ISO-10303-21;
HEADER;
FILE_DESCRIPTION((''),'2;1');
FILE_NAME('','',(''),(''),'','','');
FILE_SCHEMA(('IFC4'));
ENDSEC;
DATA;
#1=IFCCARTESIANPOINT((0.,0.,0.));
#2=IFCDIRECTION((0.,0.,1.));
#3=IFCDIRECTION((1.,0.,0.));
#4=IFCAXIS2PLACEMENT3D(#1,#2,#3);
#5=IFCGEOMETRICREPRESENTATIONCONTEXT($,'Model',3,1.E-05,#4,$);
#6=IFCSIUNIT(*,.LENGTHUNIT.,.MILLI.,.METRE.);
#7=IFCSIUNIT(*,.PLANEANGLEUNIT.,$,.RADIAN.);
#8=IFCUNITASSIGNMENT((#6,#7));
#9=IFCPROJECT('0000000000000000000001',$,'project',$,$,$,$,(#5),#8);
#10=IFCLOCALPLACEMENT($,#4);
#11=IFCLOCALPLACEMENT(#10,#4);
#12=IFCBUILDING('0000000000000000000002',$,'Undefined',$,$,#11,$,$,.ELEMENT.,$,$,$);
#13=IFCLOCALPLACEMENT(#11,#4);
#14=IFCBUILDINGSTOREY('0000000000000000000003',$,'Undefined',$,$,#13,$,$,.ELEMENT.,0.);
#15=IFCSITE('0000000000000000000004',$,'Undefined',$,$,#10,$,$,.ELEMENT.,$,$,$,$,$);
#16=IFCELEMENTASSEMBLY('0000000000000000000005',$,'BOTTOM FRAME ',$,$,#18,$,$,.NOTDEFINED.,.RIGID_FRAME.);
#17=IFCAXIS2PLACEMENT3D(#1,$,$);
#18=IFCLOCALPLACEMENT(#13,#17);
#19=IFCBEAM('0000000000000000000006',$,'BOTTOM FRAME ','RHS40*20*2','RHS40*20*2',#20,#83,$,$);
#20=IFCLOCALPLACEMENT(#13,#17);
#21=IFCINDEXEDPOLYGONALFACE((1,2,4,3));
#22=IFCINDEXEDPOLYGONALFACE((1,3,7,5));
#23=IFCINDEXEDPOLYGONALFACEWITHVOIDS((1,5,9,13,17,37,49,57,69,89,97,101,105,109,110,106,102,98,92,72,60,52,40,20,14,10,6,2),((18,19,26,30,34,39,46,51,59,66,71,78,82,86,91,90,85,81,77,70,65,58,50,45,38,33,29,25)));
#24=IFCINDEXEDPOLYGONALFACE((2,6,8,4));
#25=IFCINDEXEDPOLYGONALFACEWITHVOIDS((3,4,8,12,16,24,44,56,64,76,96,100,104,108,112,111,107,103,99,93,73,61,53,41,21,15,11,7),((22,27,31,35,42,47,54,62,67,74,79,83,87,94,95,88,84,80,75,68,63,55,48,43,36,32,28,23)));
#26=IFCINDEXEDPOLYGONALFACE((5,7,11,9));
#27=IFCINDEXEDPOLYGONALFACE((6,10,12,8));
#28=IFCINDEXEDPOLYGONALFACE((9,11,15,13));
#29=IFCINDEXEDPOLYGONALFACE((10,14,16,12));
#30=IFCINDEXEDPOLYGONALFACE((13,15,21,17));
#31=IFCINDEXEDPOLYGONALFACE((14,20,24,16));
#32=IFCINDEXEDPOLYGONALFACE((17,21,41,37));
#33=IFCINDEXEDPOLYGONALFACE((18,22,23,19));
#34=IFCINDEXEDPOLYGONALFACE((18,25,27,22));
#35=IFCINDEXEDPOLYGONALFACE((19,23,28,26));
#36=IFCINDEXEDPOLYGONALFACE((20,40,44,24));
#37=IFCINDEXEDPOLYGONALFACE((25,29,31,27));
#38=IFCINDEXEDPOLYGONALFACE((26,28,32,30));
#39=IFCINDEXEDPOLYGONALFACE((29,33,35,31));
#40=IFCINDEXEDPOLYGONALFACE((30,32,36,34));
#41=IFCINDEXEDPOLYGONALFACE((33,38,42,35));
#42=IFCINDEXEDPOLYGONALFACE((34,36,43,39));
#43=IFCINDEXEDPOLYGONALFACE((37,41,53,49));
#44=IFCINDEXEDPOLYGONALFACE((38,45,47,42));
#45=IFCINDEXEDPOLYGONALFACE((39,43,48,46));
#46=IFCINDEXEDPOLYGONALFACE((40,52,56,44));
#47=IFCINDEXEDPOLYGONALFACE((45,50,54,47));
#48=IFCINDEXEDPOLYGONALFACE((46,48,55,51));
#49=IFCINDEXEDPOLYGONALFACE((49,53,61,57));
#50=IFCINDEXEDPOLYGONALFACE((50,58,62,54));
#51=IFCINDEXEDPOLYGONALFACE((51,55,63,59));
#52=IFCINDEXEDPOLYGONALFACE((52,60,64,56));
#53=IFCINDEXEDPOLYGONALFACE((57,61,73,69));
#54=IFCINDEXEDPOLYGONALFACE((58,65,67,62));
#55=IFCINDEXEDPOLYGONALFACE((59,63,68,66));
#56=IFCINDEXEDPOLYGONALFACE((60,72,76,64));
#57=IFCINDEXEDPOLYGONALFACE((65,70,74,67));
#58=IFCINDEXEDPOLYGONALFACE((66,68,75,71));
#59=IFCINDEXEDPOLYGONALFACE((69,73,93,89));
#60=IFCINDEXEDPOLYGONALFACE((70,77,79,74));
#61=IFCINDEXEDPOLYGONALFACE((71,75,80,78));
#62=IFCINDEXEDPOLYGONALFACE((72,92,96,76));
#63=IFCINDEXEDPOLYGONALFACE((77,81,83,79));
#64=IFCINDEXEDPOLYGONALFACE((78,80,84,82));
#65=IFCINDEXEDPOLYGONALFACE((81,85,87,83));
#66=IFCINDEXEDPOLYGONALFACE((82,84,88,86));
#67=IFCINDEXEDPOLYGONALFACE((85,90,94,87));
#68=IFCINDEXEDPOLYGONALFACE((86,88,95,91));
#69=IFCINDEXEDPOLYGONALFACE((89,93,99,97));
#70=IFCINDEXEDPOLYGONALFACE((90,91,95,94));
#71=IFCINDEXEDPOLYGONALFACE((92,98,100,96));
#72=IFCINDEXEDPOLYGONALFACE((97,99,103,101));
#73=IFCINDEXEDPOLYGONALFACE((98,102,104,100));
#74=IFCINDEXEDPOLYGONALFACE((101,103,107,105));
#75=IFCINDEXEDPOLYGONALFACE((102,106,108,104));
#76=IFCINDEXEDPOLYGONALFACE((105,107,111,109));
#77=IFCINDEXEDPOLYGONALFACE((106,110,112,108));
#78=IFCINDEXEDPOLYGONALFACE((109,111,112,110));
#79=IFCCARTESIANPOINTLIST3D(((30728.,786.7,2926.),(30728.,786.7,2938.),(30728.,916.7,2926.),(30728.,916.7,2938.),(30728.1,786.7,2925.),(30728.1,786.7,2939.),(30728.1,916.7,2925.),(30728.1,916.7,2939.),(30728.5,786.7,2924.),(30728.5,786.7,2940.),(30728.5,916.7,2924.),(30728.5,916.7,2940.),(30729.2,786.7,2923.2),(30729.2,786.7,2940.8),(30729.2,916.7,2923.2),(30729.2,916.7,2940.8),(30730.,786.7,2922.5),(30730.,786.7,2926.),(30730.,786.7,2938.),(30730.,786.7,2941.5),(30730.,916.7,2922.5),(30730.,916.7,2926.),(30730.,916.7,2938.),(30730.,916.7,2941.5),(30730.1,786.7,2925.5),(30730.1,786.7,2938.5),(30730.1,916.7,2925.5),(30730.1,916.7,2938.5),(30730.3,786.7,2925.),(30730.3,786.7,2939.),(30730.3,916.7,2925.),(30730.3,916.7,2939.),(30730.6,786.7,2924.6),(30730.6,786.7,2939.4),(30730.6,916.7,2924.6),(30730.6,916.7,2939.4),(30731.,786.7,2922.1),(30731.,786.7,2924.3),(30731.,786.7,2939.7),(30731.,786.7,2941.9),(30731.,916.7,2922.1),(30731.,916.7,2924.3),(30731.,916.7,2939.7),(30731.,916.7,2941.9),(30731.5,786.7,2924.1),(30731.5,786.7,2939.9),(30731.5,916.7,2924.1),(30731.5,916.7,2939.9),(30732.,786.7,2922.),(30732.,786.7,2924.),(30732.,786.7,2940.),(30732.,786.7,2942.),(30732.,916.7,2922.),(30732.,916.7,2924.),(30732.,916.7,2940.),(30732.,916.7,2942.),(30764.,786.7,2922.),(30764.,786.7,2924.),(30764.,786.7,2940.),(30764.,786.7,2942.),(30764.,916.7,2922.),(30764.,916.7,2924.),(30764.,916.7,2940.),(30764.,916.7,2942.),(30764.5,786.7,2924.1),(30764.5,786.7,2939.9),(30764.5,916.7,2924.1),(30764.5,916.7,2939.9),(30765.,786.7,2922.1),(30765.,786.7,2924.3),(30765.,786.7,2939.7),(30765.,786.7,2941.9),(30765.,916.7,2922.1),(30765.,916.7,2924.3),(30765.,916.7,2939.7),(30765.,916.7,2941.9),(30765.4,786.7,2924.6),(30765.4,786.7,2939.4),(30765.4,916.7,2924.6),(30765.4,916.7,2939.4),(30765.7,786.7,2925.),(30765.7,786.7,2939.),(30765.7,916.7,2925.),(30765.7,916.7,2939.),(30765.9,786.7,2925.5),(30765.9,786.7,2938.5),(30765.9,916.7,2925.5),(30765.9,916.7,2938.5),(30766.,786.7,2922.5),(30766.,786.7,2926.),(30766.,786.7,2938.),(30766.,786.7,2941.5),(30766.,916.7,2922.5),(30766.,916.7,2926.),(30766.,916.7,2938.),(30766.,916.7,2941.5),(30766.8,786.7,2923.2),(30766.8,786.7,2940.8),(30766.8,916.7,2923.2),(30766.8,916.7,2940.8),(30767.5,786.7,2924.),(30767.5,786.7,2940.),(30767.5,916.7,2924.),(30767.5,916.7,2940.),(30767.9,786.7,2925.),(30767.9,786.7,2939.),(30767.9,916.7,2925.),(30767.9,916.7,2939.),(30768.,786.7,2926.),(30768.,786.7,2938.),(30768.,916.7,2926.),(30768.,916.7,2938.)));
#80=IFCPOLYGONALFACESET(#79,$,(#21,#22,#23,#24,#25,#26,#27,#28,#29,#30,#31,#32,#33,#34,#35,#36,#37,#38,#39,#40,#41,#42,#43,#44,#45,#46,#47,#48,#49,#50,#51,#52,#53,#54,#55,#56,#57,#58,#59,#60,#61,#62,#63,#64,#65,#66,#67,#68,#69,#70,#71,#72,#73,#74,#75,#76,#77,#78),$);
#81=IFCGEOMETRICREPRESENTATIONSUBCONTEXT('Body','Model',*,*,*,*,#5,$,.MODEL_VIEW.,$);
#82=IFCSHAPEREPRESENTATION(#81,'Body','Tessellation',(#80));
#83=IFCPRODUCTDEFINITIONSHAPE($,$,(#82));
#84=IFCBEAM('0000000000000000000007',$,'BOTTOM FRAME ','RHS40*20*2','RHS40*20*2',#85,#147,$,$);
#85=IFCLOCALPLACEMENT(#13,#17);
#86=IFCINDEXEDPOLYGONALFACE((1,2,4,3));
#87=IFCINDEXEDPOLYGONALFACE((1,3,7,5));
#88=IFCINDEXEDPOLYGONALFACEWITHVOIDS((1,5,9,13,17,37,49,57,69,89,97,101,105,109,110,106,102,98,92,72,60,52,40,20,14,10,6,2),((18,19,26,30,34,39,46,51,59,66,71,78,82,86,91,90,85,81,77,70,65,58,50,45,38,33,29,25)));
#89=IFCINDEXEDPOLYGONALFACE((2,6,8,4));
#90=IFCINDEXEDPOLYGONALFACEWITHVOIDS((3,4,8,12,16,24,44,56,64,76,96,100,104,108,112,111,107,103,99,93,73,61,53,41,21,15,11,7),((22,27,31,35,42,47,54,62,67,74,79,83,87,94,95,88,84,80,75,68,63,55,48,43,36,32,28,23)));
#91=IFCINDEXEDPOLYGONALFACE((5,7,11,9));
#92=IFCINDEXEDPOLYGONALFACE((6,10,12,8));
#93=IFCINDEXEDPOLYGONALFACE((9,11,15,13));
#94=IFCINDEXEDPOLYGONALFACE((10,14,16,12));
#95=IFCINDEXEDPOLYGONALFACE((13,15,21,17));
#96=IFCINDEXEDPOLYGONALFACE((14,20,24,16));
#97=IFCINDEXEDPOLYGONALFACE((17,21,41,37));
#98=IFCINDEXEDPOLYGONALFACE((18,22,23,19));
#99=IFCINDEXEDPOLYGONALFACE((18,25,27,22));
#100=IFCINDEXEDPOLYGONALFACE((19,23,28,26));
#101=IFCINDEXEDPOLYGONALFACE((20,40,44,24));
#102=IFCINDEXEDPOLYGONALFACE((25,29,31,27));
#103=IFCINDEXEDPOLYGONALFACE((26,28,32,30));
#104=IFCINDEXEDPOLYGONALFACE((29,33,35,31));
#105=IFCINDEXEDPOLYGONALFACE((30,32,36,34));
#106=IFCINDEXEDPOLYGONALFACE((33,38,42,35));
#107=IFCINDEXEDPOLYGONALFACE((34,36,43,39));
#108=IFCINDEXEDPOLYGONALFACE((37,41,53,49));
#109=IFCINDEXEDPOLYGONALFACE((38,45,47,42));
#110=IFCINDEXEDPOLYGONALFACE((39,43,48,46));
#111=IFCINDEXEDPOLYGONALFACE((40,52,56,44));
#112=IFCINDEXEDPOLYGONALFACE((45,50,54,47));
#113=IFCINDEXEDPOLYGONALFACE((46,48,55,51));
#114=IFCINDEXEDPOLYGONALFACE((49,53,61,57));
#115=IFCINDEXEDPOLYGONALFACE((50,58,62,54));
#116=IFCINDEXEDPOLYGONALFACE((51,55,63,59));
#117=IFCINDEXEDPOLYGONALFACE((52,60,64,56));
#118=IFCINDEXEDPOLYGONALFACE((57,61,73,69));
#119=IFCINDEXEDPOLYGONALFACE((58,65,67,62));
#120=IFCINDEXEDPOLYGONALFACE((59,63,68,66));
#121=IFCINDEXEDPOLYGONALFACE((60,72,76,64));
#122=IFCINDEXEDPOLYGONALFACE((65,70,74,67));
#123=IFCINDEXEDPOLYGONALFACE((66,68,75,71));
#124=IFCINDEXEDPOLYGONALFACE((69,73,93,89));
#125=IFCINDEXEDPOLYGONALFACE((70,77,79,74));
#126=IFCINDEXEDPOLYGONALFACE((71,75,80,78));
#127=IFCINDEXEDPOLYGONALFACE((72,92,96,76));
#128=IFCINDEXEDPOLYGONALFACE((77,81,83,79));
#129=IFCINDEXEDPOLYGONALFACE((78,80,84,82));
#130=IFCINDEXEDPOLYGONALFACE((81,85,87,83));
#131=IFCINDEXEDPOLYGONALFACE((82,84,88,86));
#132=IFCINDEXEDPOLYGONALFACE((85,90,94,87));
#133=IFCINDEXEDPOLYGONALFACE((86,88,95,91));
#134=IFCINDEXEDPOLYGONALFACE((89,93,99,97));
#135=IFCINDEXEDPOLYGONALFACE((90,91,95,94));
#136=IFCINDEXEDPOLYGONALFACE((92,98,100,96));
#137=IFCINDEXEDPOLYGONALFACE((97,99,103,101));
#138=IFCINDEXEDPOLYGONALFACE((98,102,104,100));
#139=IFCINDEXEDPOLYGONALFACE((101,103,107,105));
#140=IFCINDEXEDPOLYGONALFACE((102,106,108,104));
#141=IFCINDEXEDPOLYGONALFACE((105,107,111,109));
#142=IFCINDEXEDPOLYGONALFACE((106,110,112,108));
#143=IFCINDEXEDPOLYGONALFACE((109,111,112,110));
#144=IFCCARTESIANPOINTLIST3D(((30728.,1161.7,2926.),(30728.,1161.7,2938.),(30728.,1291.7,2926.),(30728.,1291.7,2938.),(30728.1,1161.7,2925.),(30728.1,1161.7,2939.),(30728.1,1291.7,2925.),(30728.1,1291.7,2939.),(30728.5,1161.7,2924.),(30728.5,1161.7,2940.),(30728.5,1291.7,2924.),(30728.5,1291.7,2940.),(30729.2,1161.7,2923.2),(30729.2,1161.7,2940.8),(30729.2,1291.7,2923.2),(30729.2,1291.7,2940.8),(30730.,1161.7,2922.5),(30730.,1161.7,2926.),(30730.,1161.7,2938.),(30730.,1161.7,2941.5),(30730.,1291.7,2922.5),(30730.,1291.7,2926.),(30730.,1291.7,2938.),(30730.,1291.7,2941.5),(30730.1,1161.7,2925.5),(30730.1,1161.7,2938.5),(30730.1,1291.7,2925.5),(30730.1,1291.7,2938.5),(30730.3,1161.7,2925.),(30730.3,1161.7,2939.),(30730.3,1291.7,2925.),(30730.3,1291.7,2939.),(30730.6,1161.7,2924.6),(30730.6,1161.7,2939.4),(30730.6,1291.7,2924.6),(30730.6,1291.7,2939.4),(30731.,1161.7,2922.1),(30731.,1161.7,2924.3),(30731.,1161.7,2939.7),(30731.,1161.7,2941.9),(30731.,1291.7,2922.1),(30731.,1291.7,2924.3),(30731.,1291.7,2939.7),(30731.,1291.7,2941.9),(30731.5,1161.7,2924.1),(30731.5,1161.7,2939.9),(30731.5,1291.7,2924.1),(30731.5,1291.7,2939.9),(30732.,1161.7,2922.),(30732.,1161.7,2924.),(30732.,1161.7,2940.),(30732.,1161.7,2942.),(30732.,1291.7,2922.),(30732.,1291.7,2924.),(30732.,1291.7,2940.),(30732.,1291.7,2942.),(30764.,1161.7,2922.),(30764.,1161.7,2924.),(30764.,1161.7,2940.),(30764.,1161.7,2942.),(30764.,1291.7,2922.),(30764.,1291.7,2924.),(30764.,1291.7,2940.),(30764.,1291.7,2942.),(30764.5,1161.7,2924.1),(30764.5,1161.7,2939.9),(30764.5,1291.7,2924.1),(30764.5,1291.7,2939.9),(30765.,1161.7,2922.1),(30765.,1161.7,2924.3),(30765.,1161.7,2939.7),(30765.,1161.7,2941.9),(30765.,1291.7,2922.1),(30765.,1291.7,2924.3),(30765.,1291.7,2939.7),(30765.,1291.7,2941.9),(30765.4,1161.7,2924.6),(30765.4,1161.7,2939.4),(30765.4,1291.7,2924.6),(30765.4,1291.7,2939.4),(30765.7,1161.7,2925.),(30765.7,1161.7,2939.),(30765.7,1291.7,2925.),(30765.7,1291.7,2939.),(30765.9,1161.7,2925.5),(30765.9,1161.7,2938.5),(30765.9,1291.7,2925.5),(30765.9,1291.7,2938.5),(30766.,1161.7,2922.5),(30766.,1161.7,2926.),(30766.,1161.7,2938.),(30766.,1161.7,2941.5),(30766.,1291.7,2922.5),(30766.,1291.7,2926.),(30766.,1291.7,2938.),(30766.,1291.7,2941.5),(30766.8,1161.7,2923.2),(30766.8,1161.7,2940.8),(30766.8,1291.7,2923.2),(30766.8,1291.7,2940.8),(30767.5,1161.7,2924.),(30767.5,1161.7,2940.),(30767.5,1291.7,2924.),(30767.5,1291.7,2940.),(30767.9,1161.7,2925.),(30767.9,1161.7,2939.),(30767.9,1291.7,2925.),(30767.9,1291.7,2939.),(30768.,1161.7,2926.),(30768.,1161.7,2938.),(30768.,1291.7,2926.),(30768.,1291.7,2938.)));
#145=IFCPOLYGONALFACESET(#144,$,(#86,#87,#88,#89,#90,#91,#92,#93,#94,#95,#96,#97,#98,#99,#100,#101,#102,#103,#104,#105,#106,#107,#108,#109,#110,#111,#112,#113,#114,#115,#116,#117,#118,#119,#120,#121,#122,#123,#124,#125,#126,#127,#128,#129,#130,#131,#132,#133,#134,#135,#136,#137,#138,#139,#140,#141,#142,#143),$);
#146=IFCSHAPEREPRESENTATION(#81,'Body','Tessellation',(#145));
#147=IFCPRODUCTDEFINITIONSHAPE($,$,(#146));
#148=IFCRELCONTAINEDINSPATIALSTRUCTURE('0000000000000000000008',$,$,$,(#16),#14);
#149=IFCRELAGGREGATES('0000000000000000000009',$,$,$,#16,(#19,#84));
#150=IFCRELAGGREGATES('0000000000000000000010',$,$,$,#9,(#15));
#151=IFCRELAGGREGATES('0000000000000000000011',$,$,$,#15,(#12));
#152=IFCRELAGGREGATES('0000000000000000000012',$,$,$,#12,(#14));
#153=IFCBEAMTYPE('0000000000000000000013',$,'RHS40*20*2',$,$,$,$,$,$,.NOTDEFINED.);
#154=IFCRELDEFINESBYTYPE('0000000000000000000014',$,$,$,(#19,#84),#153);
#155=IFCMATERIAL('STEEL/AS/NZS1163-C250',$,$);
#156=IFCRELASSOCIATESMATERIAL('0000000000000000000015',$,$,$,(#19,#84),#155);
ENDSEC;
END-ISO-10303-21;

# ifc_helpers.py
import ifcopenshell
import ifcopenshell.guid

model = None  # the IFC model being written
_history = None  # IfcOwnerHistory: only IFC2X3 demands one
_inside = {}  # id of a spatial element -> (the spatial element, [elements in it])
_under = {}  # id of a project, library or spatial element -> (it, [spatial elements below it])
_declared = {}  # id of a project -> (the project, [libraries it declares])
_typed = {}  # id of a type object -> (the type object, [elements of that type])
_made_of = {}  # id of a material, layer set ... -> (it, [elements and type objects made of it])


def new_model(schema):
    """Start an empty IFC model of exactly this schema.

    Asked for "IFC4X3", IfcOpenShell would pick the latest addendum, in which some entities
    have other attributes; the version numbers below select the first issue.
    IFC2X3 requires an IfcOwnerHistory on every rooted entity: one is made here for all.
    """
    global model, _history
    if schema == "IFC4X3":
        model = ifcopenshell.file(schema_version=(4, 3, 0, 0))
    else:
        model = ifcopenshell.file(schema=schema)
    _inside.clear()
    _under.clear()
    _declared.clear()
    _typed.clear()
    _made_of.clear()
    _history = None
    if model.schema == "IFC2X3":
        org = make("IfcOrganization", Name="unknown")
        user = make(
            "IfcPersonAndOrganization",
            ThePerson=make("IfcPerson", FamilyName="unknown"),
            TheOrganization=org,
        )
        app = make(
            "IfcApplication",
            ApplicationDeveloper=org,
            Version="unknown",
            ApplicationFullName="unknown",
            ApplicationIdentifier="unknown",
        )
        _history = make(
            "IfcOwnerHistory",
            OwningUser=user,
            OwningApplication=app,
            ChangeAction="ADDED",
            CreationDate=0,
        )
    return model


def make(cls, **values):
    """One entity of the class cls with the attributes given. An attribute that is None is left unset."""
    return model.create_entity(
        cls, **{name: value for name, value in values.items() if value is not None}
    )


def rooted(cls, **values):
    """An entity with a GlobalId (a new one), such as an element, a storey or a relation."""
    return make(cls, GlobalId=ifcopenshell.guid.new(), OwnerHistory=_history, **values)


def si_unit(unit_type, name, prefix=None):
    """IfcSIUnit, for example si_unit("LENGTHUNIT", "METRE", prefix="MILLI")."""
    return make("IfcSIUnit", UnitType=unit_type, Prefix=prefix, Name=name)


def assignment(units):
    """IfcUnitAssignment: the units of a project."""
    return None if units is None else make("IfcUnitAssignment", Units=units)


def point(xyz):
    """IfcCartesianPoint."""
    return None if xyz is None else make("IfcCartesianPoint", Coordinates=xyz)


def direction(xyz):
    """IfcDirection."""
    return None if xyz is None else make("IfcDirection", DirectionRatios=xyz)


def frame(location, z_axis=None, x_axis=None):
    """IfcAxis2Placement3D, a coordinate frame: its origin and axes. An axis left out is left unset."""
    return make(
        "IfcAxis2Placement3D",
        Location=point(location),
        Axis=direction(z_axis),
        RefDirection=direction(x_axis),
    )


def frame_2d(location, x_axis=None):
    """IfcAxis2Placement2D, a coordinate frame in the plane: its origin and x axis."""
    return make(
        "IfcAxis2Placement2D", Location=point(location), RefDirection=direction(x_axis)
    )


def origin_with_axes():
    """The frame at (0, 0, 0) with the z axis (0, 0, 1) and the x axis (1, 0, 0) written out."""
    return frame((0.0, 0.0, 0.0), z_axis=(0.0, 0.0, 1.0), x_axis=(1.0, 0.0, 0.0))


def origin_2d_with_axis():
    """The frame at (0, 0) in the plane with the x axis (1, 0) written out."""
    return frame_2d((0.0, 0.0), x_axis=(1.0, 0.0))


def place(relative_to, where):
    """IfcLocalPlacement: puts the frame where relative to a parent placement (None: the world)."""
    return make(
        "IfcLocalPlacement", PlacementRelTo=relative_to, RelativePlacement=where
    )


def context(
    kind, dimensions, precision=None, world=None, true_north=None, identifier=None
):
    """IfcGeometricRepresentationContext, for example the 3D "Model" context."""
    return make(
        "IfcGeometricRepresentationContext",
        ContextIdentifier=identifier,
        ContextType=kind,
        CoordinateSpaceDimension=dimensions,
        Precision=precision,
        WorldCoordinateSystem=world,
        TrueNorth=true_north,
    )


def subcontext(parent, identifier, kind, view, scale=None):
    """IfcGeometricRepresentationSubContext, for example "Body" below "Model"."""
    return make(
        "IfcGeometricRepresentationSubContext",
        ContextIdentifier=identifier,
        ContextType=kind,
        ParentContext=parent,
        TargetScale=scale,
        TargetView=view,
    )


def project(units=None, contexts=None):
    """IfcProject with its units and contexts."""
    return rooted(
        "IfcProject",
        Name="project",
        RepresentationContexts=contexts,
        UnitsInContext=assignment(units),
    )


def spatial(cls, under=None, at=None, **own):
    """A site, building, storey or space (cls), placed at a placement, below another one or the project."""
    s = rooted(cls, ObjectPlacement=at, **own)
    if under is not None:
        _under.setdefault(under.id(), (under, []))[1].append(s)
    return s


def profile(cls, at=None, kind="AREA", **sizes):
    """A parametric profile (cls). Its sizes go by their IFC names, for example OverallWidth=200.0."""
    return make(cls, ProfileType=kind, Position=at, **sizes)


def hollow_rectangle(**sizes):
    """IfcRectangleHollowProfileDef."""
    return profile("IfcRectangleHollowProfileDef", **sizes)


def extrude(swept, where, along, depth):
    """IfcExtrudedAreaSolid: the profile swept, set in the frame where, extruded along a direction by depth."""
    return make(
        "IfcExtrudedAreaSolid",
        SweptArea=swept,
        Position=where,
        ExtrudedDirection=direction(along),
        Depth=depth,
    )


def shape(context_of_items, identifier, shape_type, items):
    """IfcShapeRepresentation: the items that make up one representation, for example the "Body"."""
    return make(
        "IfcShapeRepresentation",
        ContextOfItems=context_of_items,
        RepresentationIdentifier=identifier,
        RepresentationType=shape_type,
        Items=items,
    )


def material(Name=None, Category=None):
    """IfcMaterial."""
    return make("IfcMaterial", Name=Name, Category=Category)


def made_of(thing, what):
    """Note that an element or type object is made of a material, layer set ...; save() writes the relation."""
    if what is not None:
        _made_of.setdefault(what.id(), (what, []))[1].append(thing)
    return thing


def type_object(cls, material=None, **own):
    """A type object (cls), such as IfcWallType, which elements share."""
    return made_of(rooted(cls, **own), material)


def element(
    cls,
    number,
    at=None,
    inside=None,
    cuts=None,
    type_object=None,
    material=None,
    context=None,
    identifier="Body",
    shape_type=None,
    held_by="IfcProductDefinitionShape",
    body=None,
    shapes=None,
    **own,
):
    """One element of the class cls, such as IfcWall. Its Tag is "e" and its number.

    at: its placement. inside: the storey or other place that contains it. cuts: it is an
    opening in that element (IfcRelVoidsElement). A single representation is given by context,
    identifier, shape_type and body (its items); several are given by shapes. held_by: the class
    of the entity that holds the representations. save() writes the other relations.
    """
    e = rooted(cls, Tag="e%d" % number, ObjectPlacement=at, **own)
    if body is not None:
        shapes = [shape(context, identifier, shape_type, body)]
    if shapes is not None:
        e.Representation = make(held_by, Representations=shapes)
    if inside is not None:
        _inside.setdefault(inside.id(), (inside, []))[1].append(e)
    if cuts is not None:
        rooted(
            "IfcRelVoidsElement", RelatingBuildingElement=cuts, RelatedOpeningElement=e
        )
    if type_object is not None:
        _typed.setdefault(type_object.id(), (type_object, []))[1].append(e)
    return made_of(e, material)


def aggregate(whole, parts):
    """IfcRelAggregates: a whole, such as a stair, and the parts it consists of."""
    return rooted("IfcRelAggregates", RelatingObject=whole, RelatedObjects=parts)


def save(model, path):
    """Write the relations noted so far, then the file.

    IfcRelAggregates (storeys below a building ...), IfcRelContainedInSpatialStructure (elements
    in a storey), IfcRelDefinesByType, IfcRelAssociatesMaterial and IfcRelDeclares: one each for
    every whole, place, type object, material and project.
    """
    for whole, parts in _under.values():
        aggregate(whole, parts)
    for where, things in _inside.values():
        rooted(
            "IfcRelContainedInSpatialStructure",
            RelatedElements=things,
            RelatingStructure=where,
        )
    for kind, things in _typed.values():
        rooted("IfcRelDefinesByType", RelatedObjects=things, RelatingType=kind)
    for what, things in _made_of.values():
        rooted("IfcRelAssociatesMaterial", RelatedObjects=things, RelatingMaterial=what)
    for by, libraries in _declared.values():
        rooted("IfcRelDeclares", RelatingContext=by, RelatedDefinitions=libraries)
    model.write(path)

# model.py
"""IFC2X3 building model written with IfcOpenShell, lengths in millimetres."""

from ifc_helpers import new_model, si_unit, frame, origin_with_axes, origin_2d_with_axis, place, context, subcontext, project, spatial, hollow_rectangle, extrude, material, type_object, element, aggregate, save


model = new_model("IFC2X3")

# Units and contexts
model_context = context("Model", 3, precision=1e-05, world=origin_with_axes())
body_context = subcontext(model_context, "Body", "Model", "MODEL_VIEW")
ifc_project = project(units=[si_unit("LENGTHUNIT", "METRE", prefix="MILLI"), si_unit("PLANEANGLEUNIT", "RADIAN")], contexts=[model_context])

# Site, building, storey
site_placement = place(None, origin_with_axes())
site = spatial("IfcSite", under=ifc_project, at=site_placement, Name="Undefined", CompositionType="ELEMENT")
building_placement = place(site_placement, origin_with_axes())
building = spatial("IfcBuilding", under=site, at=building_placement, Name="Undefined", CompositionType="ELEMENT")
storey_placement = place(building_placement, origin_with_axes())
storey = spatial("IfcBuildingStorey", under=building, at=storey_placement, Name="Undefined", CompositionType="ELEMENT", Elevation=0.0)

# Element assembly, beams
assembly_1_placement = place(storey_placement, origin_with_axes())
assembly_1 = element("IfcElementAssembly", 1, at=assembly_1_placement, inside=storey, Name="BOTTOM FRAME ", AssemblyPlace="NOTDEFINED", PredefinedType="RIGID_FRAME")
ifc_material_1 = material(Name="STEEL/AS/NZS1163-C250")
beam_type_1 = type_object("IfcBeamType", Name="RHS40*20*2", PredefinedType="NOTDEFINED")
beam_1_placement = place(assembly_1_placement, frame((30748.0, 916.7, 2932.0), z_axis=(1.0, 0.0, 0.0), x_axis=(0.0, -1.0, 0.0)))
beam_1 = element("IfcBeam", 2, at=beam_1_placement, type_object=beam_type_1, material=ifc_material_1, Name="BOTTOM FRAME ", Description="RHS40*20*2", ObjectType="RHS40*20*2", context=body_context, shape_type="SweptSolid", body=[
    extrude(hollow_rectangle(XDim=20.0, YDim=40.0, WallThickness=2.0, InnerFilletRadius=2.0, OuterFilletRadius=4.0, at=origin_2d_with_axis()), frame((130.0, 0.0, 0.0), z_axis=(-1.0, 0.0, 0.0), x_axis=(0.0, -1.0, 0.0)), (0.0, 0.0, 1.0), 130.0),
])
beam_2_placement = place(assembly_1_placement, frame((30748.0, 1291.7, 2932.0), z_axis=(1.0, 0.0, 0.0), x_axis=(0.0, -1.0, 0.0)))
beam_2 = element("IfcBeam", 3, at=beam_2_placement, type_object=beam_type_1, material=ifc_material_1, Name="BOTTOM FRAME ", Description="RHS40*20*2", ObjectType="RHS40*20*2", context=body_context, shape_type="SweptSolid", body=[
    extrude(hollow_rectangle(XDim=20.0, YDim=40.0, WallThickness=2.0, InnerFilletRadius=2.0, OuterFilletRadius=4.0, at=origin_2d_with_axis()), frame((130.0, 0.0, 0.0), z_axis=(-1.0, 0.0, 0.0), x_axis=(0.0, -1.0, 0.0)), (0.0, 0.0, 1.0), 130.0),
])
aggregate(assembly_1, [beam_1, beam_2])

save(model, "model.ifc")
